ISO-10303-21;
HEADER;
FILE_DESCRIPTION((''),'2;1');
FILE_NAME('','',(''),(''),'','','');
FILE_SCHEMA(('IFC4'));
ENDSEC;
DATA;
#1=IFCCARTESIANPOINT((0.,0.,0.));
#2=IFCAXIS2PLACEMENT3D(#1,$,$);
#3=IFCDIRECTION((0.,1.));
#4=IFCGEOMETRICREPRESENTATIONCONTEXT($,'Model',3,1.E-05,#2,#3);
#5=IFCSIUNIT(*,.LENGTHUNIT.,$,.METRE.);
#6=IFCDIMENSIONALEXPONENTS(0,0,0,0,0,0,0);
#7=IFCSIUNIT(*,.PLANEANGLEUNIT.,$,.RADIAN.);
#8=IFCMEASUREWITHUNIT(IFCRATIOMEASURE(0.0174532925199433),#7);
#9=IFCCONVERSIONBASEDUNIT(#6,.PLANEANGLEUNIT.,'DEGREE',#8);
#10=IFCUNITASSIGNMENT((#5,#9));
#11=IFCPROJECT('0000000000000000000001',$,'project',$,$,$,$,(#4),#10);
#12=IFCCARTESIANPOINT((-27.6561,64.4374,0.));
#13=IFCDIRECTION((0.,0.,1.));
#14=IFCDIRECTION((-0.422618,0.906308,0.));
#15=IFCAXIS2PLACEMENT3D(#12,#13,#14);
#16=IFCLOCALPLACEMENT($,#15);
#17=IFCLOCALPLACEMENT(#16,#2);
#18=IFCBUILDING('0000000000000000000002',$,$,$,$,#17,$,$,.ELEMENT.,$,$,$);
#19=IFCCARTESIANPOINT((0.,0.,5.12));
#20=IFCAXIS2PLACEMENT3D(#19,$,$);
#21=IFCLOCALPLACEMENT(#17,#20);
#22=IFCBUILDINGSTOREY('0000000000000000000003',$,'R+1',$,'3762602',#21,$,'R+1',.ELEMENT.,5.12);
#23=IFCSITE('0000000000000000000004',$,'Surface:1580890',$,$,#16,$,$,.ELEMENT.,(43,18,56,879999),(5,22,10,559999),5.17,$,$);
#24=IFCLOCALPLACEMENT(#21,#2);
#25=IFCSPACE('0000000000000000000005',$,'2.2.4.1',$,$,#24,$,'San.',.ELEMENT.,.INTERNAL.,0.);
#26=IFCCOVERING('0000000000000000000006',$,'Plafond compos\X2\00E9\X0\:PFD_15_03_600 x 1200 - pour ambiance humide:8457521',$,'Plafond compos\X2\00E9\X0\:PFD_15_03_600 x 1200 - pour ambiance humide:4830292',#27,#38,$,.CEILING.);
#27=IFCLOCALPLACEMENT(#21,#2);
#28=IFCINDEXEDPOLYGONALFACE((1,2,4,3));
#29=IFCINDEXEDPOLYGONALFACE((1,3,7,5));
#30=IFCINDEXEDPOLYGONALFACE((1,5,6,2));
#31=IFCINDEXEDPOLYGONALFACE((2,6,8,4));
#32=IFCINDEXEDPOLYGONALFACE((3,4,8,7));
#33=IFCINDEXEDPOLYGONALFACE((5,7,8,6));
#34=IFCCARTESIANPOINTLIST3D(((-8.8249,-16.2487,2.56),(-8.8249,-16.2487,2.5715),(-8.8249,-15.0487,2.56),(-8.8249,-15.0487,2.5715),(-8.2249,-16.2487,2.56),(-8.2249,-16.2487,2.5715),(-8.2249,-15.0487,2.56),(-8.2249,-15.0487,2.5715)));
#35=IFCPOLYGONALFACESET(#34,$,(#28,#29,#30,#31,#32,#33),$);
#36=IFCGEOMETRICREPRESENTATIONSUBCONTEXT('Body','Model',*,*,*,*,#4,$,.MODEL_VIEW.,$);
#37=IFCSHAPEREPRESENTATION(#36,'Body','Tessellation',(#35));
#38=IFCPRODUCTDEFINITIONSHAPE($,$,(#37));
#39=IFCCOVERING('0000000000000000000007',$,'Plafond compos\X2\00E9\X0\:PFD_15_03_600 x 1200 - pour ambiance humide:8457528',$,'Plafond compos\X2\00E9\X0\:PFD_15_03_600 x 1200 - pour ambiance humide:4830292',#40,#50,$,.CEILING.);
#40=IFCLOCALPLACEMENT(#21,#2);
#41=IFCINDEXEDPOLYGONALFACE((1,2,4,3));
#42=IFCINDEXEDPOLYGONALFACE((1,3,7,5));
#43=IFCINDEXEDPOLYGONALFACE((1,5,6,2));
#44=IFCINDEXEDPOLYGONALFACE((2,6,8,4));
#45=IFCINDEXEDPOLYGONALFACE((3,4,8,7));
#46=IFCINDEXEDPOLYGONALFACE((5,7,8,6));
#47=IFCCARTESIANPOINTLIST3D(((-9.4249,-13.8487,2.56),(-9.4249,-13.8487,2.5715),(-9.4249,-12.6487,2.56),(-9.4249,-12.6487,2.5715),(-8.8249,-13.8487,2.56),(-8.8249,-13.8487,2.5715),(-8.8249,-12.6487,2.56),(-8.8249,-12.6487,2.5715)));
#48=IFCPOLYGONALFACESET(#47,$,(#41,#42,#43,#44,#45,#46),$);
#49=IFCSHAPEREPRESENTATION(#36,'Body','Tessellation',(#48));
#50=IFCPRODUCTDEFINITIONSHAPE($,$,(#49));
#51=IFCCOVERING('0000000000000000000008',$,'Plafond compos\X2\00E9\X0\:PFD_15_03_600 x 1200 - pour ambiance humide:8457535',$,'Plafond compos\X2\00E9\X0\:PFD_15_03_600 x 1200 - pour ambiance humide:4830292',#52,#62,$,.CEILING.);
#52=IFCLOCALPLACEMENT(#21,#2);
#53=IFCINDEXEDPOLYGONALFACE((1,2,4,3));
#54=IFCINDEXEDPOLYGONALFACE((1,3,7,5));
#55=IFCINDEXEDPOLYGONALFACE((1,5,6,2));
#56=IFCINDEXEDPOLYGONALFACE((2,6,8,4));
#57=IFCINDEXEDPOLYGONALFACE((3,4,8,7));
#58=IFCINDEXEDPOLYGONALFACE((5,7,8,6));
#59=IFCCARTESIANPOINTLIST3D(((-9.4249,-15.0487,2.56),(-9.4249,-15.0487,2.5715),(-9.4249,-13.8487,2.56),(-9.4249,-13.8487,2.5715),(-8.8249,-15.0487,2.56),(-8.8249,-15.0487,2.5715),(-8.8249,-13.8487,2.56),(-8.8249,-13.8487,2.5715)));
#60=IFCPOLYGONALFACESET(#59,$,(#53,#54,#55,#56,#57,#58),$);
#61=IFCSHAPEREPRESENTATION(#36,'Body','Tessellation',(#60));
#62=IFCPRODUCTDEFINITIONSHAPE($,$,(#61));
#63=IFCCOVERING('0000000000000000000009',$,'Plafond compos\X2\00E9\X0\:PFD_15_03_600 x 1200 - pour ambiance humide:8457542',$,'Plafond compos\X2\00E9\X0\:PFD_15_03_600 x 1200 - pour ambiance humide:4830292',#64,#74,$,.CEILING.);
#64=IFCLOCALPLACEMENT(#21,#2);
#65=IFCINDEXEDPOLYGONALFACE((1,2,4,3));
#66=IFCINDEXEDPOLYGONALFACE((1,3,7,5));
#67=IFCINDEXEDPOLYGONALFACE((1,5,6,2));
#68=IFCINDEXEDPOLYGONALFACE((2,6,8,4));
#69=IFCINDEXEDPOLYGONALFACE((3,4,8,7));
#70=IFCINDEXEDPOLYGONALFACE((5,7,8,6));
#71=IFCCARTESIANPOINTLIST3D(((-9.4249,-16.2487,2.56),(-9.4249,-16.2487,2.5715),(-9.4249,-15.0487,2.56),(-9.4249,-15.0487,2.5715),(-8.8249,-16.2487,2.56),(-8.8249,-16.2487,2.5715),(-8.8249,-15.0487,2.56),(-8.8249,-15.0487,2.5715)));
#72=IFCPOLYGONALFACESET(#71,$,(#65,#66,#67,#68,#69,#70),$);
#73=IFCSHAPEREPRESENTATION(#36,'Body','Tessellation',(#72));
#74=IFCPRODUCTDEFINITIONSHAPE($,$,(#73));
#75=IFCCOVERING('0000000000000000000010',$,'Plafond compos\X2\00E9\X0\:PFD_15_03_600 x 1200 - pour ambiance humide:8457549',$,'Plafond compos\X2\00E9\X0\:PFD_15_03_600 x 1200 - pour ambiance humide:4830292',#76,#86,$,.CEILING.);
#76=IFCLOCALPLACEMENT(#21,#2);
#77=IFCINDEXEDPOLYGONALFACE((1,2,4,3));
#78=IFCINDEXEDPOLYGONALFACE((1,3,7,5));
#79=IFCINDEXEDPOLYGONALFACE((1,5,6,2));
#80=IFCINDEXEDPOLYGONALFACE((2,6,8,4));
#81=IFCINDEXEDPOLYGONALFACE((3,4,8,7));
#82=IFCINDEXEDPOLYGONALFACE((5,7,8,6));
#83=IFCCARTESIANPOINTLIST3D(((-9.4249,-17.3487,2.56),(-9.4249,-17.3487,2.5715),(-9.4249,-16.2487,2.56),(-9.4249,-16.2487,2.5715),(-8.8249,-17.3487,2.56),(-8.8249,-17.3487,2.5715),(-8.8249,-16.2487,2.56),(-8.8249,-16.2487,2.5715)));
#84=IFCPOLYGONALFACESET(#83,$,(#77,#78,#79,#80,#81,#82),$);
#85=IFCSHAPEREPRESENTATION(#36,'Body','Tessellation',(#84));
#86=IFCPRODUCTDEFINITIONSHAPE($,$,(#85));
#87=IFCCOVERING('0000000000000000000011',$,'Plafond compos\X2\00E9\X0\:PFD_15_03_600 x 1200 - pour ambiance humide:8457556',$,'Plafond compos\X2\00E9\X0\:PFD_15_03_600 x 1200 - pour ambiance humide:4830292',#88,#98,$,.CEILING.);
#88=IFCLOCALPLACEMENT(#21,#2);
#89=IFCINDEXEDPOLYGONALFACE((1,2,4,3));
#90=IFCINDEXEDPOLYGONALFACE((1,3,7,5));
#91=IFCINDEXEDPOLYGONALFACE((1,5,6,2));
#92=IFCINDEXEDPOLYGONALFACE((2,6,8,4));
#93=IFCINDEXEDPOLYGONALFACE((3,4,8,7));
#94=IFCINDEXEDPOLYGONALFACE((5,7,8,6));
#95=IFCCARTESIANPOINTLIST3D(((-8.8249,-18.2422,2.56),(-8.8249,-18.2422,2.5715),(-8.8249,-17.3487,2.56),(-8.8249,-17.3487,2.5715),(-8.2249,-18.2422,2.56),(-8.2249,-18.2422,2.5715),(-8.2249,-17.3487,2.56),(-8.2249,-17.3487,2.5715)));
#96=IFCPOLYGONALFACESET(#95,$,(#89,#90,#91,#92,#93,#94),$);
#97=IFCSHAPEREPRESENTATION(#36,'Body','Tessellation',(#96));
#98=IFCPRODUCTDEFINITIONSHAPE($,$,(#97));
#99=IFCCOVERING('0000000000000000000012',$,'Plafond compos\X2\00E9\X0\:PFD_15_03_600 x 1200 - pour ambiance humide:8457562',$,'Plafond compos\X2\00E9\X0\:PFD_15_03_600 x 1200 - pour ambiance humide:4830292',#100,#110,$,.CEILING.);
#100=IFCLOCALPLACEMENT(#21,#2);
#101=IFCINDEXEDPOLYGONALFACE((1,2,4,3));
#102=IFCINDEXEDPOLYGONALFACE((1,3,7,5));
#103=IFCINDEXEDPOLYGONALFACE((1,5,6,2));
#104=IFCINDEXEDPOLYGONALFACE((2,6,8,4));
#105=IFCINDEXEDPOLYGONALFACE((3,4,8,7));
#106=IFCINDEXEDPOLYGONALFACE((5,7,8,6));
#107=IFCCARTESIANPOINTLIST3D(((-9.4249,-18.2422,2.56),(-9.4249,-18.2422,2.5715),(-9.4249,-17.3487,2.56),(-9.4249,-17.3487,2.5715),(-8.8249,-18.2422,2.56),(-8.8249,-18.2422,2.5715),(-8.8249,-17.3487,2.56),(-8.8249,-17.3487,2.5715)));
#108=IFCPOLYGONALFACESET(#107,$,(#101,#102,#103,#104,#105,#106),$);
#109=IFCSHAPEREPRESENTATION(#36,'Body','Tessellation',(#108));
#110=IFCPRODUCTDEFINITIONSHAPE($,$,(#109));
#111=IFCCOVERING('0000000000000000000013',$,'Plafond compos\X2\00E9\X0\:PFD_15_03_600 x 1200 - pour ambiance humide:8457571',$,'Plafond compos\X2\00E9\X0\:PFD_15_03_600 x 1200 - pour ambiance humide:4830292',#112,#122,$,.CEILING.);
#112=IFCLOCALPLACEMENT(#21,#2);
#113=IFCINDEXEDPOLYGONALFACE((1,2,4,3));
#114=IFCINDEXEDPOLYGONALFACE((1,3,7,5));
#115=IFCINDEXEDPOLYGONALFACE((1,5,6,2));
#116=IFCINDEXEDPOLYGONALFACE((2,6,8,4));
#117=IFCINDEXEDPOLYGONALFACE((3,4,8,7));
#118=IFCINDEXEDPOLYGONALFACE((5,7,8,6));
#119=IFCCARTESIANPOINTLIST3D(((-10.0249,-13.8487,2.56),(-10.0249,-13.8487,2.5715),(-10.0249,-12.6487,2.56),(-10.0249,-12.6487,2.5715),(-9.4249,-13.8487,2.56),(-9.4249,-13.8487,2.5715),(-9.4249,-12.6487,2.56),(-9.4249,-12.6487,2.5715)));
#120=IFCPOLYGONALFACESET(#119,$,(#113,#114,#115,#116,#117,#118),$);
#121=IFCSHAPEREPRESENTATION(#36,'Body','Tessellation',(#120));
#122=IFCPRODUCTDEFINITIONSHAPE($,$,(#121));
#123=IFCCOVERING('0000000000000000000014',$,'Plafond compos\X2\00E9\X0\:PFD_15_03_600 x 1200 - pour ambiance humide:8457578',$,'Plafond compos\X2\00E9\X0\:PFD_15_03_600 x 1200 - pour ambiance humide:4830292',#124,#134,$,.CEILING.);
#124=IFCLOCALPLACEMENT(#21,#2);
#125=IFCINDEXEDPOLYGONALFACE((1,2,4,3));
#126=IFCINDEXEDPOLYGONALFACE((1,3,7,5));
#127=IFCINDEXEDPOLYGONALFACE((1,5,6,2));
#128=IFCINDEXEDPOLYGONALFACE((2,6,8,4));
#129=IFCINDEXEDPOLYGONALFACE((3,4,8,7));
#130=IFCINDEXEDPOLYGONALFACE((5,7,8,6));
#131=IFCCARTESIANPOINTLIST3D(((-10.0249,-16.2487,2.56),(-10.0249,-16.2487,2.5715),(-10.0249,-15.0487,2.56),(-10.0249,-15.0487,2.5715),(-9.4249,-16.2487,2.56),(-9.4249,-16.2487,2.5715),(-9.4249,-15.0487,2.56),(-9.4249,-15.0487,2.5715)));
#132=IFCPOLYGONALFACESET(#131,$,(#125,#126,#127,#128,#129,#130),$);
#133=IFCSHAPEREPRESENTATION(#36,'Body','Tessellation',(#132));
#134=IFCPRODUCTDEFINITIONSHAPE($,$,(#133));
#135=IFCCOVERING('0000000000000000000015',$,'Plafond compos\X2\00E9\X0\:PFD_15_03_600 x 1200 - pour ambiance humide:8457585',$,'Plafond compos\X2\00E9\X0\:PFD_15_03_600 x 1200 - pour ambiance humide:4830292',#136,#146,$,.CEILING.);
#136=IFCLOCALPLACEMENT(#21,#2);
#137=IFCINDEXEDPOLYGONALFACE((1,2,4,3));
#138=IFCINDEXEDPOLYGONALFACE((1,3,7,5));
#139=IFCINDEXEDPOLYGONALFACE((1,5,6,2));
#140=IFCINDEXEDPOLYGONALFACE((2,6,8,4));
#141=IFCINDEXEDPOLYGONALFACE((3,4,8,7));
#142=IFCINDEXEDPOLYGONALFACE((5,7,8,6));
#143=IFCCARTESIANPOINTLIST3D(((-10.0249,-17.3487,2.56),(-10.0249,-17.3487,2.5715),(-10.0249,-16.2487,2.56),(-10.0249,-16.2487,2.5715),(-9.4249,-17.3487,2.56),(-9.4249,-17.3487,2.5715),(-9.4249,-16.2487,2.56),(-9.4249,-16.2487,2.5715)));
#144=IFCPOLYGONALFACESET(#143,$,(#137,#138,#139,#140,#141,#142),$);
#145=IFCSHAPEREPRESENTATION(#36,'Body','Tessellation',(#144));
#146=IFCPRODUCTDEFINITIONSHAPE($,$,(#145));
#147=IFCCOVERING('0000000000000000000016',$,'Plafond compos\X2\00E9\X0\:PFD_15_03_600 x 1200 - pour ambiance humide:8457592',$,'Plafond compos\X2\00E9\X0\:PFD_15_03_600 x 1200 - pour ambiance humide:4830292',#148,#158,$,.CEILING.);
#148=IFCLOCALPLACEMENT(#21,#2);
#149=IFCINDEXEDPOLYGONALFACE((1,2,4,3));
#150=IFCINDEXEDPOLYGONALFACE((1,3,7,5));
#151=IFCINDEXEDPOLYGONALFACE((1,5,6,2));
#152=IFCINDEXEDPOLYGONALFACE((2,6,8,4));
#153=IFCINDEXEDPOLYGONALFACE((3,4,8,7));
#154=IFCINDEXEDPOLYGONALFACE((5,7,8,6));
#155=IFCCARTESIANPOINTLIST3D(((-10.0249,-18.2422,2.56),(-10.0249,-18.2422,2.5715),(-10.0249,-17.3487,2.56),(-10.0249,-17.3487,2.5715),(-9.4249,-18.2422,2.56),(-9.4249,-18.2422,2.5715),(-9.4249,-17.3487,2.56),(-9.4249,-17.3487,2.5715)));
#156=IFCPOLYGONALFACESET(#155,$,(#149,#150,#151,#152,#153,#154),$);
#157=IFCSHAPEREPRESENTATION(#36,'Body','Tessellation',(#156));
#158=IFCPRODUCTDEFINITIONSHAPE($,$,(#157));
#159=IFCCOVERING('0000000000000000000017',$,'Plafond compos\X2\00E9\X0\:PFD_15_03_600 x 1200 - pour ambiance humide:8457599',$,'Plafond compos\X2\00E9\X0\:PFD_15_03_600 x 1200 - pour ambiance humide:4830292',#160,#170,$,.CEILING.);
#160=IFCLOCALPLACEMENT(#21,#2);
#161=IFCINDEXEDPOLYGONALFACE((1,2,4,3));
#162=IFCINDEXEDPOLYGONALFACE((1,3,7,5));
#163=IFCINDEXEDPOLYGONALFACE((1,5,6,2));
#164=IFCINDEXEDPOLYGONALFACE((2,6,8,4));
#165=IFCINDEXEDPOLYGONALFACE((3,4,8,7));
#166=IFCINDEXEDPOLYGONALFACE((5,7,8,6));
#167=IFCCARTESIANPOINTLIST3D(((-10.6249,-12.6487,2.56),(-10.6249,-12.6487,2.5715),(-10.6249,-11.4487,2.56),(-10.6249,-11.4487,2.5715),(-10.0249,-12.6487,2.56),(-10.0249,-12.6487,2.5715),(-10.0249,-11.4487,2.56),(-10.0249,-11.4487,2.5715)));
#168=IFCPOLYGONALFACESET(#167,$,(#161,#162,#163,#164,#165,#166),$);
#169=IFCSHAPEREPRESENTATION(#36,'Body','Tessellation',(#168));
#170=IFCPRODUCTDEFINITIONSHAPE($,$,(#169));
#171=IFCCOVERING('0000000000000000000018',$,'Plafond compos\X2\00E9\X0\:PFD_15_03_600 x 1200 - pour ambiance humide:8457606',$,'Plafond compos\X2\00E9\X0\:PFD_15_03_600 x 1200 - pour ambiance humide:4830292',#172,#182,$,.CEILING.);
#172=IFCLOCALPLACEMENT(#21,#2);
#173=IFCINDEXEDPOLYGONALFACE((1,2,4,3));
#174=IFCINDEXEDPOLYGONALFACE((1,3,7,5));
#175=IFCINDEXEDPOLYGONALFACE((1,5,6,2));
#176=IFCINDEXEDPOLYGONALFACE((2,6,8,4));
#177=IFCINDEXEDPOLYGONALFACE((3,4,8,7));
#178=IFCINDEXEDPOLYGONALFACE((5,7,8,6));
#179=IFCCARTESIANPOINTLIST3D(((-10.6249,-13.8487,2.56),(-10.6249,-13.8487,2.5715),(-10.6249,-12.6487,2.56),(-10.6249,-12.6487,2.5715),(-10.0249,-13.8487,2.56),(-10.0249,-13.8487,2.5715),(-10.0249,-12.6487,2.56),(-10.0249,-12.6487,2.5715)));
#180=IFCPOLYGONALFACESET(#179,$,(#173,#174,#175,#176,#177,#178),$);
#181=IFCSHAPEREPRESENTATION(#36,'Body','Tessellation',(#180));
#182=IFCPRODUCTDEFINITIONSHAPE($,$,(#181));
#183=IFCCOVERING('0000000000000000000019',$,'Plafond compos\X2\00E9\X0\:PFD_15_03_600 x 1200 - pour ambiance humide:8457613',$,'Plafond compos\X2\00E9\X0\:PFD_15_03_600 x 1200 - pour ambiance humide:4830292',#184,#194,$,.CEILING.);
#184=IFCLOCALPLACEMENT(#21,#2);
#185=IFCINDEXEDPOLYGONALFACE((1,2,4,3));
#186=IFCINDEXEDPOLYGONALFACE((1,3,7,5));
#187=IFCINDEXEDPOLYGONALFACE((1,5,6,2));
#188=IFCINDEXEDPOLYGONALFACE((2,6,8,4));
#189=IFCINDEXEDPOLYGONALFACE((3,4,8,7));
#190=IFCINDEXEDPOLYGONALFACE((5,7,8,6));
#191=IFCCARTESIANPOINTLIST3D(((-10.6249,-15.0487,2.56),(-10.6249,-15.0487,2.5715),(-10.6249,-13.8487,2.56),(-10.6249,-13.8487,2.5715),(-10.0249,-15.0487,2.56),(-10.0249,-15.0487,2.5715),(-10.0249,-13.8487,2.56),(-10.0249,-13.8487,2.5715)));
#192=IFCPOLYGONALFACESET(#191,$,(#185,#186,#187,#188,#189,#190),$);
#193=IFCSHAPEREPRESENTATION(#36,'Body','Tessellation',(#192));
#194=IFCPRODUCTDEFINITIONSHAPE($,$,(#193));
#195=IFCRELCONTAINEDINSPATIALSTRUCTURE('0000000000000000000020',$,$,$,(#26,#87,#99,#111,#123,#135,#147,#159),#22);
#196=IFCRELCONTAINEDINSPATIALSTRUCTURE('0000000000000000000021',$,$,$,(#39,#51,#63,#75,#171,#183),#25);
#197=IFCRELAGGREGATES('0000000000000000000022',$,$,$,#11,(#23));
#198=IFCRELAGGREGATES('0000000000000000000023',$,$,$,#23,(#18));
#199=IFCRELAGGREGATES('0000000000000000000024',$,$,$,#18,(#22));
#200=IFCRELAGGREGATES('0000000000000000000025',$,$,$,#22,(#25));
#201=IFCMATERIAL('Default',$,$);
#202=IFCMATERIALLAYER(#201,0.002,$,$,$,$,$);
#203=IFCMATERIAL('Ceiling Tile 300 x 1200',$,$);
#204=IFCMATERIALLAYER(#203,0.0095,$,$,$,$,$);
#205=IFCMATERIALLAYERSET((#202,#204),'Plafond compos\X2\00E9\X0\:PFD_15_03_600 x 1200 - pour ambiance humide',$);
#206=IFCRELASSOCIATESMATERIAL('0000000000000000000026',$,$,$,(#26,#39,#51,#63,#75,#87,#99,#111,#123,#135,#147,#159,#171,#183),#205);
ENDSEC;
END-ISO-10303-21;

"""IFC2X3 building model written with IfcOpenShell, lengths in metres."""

from ifc_helpers import new_model, entity, si_unit, converted_unit, direction, frame, frame_2d, origin, origin_2d_with_axis, place, context, subcontext, project, spatial, rectangle, extrude, material, layer, layer_set, layer_usage, element, save


model = new_model("IFC2X3")

# Units and contexts
model_context = context("Model", 3, precision=1e-05, world=origin(), true_north=direction((0.0, 1.0)))
body_context = subcontext(model_context, "Body", "Model", "MODEL_VIEW")
ifc_project = project(units=[si_unit("LENGTHUNIT", "METRE"), converted_unit("PLANEANGLEUNIT", "DEGREE", entity("IfcRatioMeasure", 0.0174532925199433), si_unit("PLANEANGLEUNIT", "RADIAN"), dimensions=[0, 0, 0, 0, 0, 0, 0])], contexts=[model_context])

# Site, building, storey
site_placement = place(None, frame((-27.6561, 64.4374, 0.0), z_axis=(0.0, 0.0, 1.0), x_axis=(-0.422618, 0.906308, 0.0)))
site = spatial("IfcSite", under=ifc_project, at=site_placement, Name="Surface:1580890", CompositionType="ELEMENT", RefLatitude=(43, 18, 56, 879999), RefLongitude=(5, 22, 10, 559999), RefElevation=5.17)
building_placement = place(site_placement, origin())
building = spatial("IfcBuilding", under=site, at=building_placement, CompositionType="ELEMENT")
storey_placement = place(building_placement, frame((0.0, 0.0, 5.12)))
storey = spatial("IfcBuildingStorey", under=building, at=storey_placement, Name="R+1", ObjectType="3762602", LongName="R+1", CompositionType="ELEMENT", Elevation=5.12)

# Covering
ifc_material_1 = material(Name="Default")
ifc_layer_1 = layer(ifc_material_1, 0.002)
ifc_material_2 = material(Name="Ceiling Tile 300 x 1200")
ifc_layer_2 = layer(ifc_material_2, 0.0095)
ifc_layer_set = layer_set([ifc_layer_1, ifc_layer_2], Name="Plafond composé:PFD_15_03_600 x 1200 - pour ambiance humide")
ifc_layer_usage_1 = layer_usage(ifc_layer_set, "AXIS3", "POSITIVE", 0.0)
covering_1_placement = place(storey_placement, origin())
element("IfcCovering", 1, at=covering_1_placement, inside=storey, material=ifc_layer_usage_1, Name="Plafond composé:PFD_15_03_600 x 1200 - pour ambiance humide:8457521", ObjectType="Plafond composé:PFD_15_03_600 x 1200 - pour ambiance humide:4830292", PredefinedType="CEILING", context=body_context, shape_type="SweptSolid", body=[
    extrude(rectangle(XDim=0.6, YDim=1.2, at=frame_2d((0.0, 0.0), x_axis=(1.0, 0.0))), frame((-8.5249, -15.6487, 2.56), z_axis=(0.0, 0.0, 1.0), x_axis=(-1.0, 0.0, 0.0)), (0.0, 0.0, 1.0), 0.0115),
])

# Shared definitions
space_placement = place(storey_placement, origin())
space = spatial("IfcSpace", under=storey, at=space_placement, Name="2.2.4.1", LongName="San.", CompositionType="ELEMENT", InteriorOrExteriorSpace="INTERNAL", ElevationWithFlooring=0.0)

# Coverings
ifc_layer_usage_2 = layer_usage(ifc_layer_set, "AXIS3", "POSITIVE", 0.0)
covering_2_placement = place(space_placement, origin())
element("IfcCovering", 2, at=covering_2_placement, inside=space, material=ifc_layer_usage_2, Name="Plafond composé:PFD_15_03_600 x 1200 - pour ambiance humide:8457528", ObjectType="Plafond composé:PFD_15_03_600 x 1200 - pour ambiance humide:4830292", PredefinedType="CEILING", context=body_context, shape_type="SweptSolid", body=[
    extrude(rectangle(XDim=0.6, YDim=1.2, at=origin_2d_with_axis()), frame((-9.1249, -13.2487, 2.56), z_axis=(0.0, 0.0, 1.0), x_axis=(-1.0, 0.0, 0.0)), (0.0, 0.0, 1.0), 0.0115),
])
ifc_layer_usage_3 = layer_usage(ifc_layer_set, "AXIS3", "POSITIVE", 0.0)
covering_3_placement = place(space_placement, origin())
element("IfcCovering", 3, at=covering_3_placement, inside=space, material=ifc_layer_usage_3, Name="Plafond composé:PFD_15_03_600 x 1200 - pour ambiance humide:8457535", ObjectType="Plafond composé:PFD_15_03_600 x 1200 - pour ambiance humide:4830292", PredefinedType="CEILING", context=body_context, shape_type="SweptSolid", body=[
    extrude(rectangle(XDim=0.6, YDim=1.2, at=frame_2d((0.0, 0.0), x_axis=(1.0, 0.0))), frame((-9.1249, -14.4487, 2.56), z_axis=(0.0, 0.0, 1.0), x_axis=(-1.0, 0.0, 0.0)), (0.0, 0.0, 1.0), 0.0115),
])
ifc_layer_usage_4 = layer_usage(ifc_layer_set, "AXIS3", "POSITIVE", 0.0)
covering_4_placement = place(space_placement, origin())
element("IfcCovering", 4, at=covering_4_placement, inside=space, material=ifc_layer_usage_4, Name="Plafond composé:PFD_15_03_600 x 1200 - pour ambiance humide:8457542", ObjectType="Plafond composé:PFD_15_03_600 x 1200 - pour ambiance humide:4830292", PredefinedType="CEILING", context=body_context, shape_type="SweptSolid", body=[
    extrude(rectangle(XDim=0.6, YDim=1.2, at=frame_2d((0.0, 0.0), x_axis=(1.0, 0.0))), frame((-9.1249, -15.6487, 2.56), z_axis=(0.0, 0.0, 1.0), x_axis=(-1.0, 0.0, 0.0)), (0.0, 0.0, 1.0), 0.0115),
])
ifc_layer_usage_5 = layer_usage(ifc_layer_set, "AXIS3", "POSITIVE", 0.0)
covering_5_placement = place(space_placement, origin())
element("IfcCovering", 5, at=covering_5_placement, inside=space, material=ifc_layer_usage_5, Name="Plafond composé:PFD_15_03_600 x 1200 - pour ambiance humide:8457549", ObjectType="Plafond composé:PFD_15_03_600 x 1200 - pour ambiance humide:4830292", PredefinedType="CEILING", context=body_context, shape_type="SweptSolid", body=[
    extrude(rectangle(XDim=0.6, YDim=1.1, at=frame_2d((0.0, 0.0), x_axis=(1.0, 0.0))), frame((-9.1249, -16.7987, 2.56), z_axis=(0.0, 0.0, 1.0), x_axis=(-1.0, 0.0, 0.0)), (0.0, 0.0, 1.0), 0.0115),
])
ifc_layer_usage_6 = layer_usage(ifc_layer_set, "AXIS3", "POSITIVE", 0.0)
covering_6_placement = place(storey_placement, origin())
element("IfcCovering", 6, at=covering_6_placement, inside=storey, material=ifc_layer_usage_6, Name="Plafond composé:PFD_15_03_600 x 1200 - pour ambiance humide:8457556", ObjectType="Plafond composé:PFD_15_03_600 x 1200 - pour ambiance humide:4830292", PredefinedType="CEILING", context=body_context, shape_type="SweptSolid", body=[
    extrude(rectangle(XDim=0.6, YDim=0.8935, at=frame_2d((0.0, 0.0), x_axis=(1.0, 0.0))), frame((-8.5249, -17.7955, 2.56), z_axis=(0.0, 0.0, 1.0), x_axis=(-1.0, 0.0, 0.0)), (0.0, 0.0, 1.0), 0.0115),
])
ifc_layer_usage_7 = layer_usage(ifc_layer_set, "AXIS3", "POSITIVE", 0.0)
covering_7_placement = place(storey_placement, origin())
element("IfcCovering", 7, at=covering_7_placement, inside=storey, material=ifc_layer_usage_7, Name="Plafond composé:PFD_15_03_600 x 1200 - pour ambiance humide:8457562", ObjectType="Plafond composé:PFD_15_03_600 x 1200 - pour ambiance humide:4830292", PredefinedType="CEILING", context=body_context, shape_type="SweptSolid", body=[
    extrude(rectangle(XDim=0.6, YDim=0.8935, at=frame_2d((0.0, 0.0), x_axis=(1.0, 0.0))), frame((-9.1249, -17.7955, 2.56), z_axis=(0.0, 0.0, 1.0), x_axis=(-1.0, 0.0, 0.0)), (0.0, 0.0, 1.0), 0.0115),
])
ifc_layer_usage_8 = layer_usage(ifc_layer_set, "AXIS3", "POSITIVE", 0.0)
covering_8_placement = place(storey_placement, origin())
element("IfcCovering", 8, at=covering_8_placement, inside=storey, material=ifc_layer_usage_8, Name="Plafond composé:PFD_15_03_600 x 1200 - pour ambiance humide:8457571", ObjectType="Plafond composé:PFD_15_03_600 x 1200 - pour ambiance humide:4830292", PredefinedType="CEILING", context=body_context, shape_type="SweptSolid", body=[
    extrude(rectangle(XDim=0.6, YDim=1.2, at=frame_2d((0.0, 0.0), x_axis=(1.0, 0.0))), frame((-9.7249, -13.2487, 2.56), z_axis=(0.0, 0.0, 1.0), x_axis=(-1.0, 0.0, 0.0)), (0.0, 0.0, 1.0), 0.0115),
])
ifc_layer_usage_9 = layer_usage(ifc_layer_set, "AXIS3", "POSITIVE", 0.0)
covering_9_placement = place(storey_placement, origin())
element("IfcCovering", 9, at=covering_9_placement, inside=storey, material=ifc_layer_usage_9, Name="Plafond composé:PFD_15_03_600 x 1200 - pour ambiance humide:8457578", ObjectType="Plafond composé:PFD_15_03_600 x 1200 - pour ambiance humide:4830292", PredefinedType="CEILING", context=body_context, shape_type="SweptSolid", body=[
    extrude(rectangle(XDim=0.6, YDim=1.2, at=origin_2d_with_axis()), frame((-9.7249, -15.6487, 2.56), z_axis=(0.0, 0.0, 1.0), x_axis=(-1.0, 0.0, 0.0)), (0.0, 0.0, 1.0), 0.0115),
])
ifc_layer_usage_10 = layer_usage(ifc_layer_set, "AXIS3", "POSITIVE", 0.0)
covering_10_placement = place(storey_placement, origin())
element("IfcCovering", 10, at=covering_10_placement, inside=storey, material=ifc_layer_usage_10, Name="Plafond composé:PFD_15_03_600 x 1200 - pour ambiance humide:8457585", ObjectType="Plafond composé:PFD_15_03_600 x 1200 - pour ambiance humide:4830292", PredefinedType="CEILING", context=body_context, shape_type="SweptSolid", body=[
    extrude(rectangle(XDim=0.6, YDim=1.1, at=frame_2d((0.0, 0.0), x_axis=(1.0, 0.0))), frame((-9.7249, -16.7987, 2.56), z_axis=(0.0, 0.0, 1.0), x_axis=(-1.0, 0.0, 0.0)), (0.0, 0.0, 1.0), 0.0115),
])
ifc_layer_usage_11 = layer_usage(ifc_layer_set, "AXIS3", "POSITIVE", 0.0)
covering_11_placement = place(storey_placement, origin())
element("IfcCovering", 11, at=covering_11_placement, inside=storey, material=ifc_layer_usage_11, Name="Plafond composé:PFD_15_03_600 x 1200 - pour ambiance humide:8457592", ObjectType="Plafond composé:PFD_15_03_600 x 1200 - pour ambiance humide:4830292", PredefinedType="CEILING", context=body_context, shape_type="SweptSolid", body=[
    extrude(rectangle(XDim=0.6, YDim=0.8935, at=frame_2d((0.0, 0.0), x_axis=(1.0, 0.0))), frame((-9.7249, -17.7955, 2.56), z_axis=(0.0, 0.0, 1.0), x_axis=(-1.0, 0.0, 0.0)), (0.0, 0.0, 1.0), 0.0115),
])
ifc_layer_usage_12 = layer_usage(ifc_layer_set, "AXIS3", "POSITIVE", 0.0)
covering_12_placement = place(storey_placement, origin())
element("IfcCovering", 12, at=covering_12_placement, inside=storey, material=ifc_layer_usage_12, Name="Plafond composé:PFD_15_03_600 x 1200 - pour ambiance humide:8457599", ObjectType="Plafond composé:PFD_15_03_600 x 1200 - pour ambiance humide:4830292", PredefinedType="CEILING", context=body_context, shape_type="SweptSolid", body=[
    extrude(rectangle(XDim=0.6, YDim=1.2, at=frame_2d((0.0, 0.0), x_axis=(1.0, 0.0))), frame((-10.3249, -12.0487, 2.56), z_axis=(0.0, 0.0, 1.0), x_axis=(-1.0, 0.0, 0.0)), (0.0, 0.0, 1.0), 0.0115),
])
ifc_layer_usage_13 = layer_usage(ifc_layer_set, "AXIS3", "POSITIVE", 0.0)
covering_13_placement = place(space_placement, origin())
element("IfcCovering", 13, at=covering_13_placement, inside=space, material=ifc_layer_usage_13, Name="Plafond composé:PFD_15_03_600 x 1200 - pour ambiance humide:8457606", ObjectType="Plafond composé:PFD_15_03_600 x 1200 - pour ambiance humide:4830292", PredefinedType="CEILING", context=body_context, shape_type="SweptSolid", body=[
    extrude(rectangle(XDim=0.6, YDim=1.2, at=frame_2d((0.0, 0.0), x_axis=(1.0, 0.0))), frame((-10.3249, -13.2487, 2.56), z_axis=(0.0, 0.0, 1.0), x_axis=(-1.0, 0.0, 0.0)), (0.0, 0.0, 1.0), 0.0115),
])
ifc_layer_usage_14 = layer_usage(ifc_layer_set, "AXIS3", "POSITIVE", 0.0)
covering_14_placement = place(space_placement, origin())
element("IfcCovering", 14, at=covering_14_placement, inside=space, material=ifc_layer_usage_14, Name="Plafond composé:PFD_15_03_600 x 1200 - pour ambiance humide:8457613", ObjectType="Plafond composé:PFD_15_03_600 x 1200 - pour ambiance humide:4830292", PredefinedType="CEILING", context=body_context, shape_type="SweptSolid", body=[
    extrude(rectangle(XDim=0.6, YDim=1.2, at=frame_2d((0.0, 0.0), x_axis=(1.0, 0.0))), frame((-10.3249, -14.4487, 2.56), z_axis=(0.0, 0.0, 1.0), x_axis=(-1.0, 0.0, 0.0)), (0.0, 0.0, 1.0), 0.0115),
])

save(model, "model.ifc")
